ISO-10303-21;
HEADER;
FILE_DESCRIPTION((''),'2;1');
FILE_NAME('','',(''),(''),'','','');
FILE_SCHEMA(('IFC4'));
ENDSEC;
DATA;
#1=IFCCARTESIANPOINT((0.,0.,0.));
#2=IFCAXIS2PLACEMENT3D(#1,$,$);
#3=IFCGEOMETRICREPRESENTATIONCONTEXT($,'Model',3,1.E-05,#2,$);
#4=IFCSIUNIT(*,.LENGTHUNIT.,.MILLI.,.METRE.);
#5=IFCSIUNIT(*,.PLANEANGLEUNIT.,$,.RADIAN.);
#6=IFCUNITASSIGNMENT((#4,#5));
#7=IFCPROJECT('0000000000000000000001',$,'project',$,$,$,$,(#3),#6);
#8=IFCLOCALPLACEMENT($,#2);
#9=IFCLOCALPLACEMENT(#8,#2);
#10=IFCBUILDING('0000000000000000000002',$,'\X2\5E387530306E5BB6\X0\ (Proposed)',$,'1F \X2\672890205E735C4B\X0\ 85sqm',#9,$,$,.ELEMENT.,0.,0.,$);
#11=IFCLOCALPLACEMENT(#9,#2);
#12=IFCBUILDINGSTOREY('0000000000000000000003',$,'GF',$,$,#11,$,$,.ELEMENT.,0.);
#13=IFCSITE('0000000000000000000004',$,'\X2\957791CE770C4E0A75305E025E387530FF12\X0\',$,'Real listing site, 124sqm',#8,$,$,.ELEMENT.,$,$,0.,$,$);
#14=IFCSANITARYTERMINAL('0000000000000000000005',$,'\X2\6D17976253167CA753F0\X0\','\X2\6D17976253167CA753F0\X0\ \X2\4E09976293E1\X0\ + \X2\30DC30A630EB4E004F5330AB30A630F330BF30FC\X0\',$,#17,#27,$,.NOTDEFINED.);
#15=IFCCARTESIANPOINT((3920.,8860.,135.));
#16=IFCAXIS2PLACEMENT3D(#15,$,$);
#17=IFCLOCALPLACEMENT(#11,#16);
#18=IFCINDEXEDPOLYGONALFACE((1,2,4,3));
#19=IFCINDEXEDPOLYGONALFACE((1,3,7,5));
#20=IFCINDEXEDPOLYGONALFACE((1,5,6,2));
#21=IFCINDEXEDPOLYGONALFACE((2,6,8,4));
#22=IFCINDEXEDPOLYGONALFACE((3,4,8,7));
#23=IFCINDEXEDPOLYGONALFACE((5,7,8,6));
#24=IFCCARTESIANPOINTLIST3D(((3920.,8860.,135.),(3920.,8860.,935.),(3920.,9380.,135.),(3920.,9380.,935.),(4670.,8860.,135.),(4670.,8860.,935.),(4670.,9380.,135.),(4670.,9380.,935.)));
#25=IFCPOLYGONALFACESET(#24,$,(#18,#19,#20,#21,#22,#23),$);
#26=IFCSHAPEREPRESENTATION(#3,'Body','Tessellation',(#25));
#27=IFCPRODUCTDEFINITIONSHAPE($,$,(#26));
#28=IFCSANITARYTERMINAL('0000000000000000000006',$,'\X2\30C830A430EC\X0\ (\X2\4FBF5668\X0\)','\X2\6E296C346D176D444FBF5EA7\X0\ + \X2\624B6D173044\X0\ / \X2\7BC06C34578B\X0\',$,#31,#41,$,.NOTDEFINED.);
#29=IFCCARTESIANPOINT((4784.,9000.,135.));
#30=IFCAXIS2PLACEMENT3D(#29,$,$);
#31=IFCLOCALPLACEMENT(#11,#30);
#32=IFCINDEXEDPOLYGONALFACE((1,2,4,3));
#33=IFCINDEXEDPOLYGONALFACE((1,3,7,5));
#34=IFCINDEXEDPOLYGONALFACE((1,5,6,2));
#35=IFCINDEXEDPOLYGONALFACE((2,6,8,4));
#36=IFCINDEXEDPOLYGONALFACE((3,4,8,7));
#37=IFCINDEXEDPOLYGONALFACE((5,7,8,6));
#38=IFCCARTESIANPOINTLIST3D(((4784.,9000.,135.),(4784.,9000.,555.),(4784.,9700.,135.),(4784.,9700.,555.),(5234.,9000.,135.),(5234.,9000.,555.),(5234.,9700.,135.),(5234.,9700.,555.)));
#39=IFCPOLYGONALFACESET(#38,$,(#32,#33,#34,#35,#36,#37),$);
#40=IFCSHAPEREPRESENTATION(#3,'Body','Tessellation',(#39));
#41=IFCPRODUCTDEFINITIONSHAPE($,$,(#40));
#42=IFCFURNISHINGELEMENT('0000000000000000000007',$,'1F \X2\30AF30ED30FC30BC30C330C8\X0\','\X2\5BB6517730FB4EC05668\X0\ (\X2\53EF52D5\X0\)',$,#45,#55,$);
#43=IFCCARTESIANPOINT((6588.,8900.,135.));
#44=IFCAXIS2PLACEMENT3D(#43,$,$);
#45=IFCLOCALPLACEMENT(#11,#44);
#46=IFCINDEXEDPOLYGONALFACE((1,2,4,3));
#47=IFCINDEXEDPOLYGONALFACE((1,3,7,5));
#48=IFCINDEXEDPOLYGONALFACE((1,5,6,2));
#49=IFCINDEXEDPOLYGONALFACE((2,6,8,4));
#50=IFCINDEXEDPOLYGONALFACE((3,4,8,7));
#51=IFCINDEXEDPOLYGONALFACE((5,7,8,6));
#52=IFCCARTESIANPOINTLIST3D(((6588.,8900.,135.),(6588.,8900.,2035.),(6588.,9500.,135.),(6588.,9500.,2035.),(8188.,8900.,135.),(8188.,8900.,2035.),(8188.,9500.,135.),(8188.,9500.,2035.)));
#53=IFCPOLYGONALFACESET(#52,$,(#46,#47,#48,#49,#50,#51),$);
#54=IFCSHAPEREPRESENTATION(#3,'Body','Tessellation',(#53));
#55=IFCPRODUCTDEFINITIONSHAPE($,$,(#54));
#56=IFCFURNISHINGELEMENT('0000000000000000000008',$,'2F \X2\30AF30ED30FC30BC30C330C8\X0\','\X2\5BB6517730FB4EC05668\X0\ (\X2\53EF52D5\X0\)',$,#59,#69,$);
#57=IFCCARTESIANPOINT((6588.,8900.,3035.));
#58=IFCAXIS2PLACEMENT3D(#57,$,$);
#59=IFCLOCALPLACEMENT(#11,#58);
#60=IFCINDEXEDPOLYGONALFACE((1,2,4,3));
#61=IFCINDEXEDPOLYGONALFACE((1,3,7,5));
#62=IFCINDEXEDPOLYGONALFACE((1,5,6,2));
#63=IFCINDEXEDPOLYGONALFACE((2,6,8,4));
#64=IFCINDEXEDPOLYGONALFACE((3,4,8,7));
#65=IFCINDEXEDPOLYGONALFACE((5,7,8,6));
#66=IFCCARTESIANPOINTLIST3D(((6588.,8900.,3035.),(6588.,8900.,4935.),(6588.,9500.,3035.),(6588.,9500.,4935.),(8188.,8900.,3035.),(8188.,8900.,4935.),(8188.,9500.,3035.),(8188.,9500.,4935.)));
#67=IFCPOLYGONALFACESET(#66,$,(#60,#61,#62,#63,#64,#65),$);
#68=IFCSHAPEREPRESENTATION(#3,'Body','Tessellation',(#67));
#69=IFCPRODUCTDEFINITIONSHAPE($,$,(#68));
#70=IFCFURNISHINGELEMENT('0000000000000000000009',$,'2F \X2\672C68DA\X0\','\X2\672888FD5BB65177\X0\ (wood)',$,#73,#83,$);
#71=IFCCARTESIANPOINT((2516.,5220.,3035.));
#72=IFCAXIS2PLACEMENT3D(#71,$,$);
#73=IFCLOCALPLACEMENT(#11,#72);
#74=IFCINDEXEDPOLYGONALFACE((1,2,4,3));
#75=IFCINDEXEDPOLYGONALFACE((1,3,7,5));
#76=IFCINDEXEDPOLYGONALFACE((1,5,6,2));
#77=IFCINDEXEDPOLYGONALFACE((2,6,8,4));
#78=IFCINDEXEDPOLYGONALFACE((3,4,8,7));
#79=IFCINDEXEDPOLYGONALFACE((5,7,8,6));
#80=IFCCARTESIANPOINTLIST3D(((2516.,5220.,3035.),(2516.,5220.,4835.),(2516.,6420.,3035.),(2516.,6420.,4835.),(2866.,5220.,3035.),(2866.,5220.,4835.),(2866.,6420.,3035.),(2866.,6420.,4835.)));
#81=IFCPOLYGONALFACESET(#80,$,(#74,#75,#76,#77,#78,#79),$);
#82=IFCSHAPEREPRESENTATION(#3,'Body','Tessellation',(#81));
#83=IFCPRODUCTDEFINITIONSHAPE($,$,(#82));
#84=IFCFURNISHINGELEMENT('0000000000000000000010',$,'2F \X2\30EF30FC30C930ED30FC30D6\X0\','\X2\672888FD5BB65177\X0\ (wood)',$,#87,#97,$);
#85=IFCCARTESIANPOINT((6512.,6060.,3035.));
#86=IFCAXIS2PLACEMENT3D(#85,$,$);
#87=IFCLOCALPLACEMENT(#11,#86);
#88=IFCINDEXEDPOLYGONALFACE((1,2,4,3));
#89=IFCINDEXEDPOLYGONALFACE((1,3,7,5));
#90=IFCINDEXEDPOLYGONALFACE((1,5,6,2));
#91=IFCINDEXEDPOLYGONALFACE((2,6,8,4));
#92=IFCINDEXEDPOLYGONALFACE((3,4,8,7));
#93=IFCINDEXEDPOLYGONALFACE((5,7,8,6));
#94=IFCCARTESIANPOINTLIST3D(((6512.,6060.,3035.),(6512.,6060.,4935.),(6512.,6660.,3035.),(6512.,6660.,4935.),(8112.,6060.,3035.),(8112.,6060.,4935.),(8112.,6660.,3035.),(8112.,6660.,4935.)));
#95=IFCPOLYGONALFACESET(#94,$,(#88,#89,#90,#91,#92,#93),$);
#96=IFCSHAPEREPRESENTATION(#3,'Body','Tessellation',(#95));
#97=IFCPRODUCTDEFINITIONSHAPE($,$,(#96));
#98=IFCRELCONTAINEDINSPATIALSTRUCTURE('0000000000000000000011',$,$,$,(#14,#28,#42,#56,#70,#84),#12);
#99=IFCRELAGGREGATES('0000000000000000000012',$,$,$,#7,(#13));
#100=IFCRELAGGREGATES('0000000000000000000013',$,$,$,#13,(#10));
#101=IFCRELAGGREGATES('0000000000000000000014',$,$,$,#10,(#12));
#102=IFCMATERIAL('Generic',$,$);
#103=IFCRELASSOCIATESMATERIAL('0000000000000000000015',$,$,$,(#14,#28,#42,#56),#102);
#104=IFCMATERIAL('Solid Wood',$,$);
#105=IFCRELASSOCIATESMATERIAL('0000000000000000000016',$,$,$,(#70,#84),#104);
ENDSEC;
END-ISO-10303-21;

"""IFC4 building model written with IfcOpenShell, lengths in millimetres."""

from ifc_helpers import new_model, si_unit, frame, frame_2d, origin, place, context, project, spatial, rectangle, extrude, material, element, save


model = new_model("IFC4")

# Units and contexts
model_context = context("Model", 3, precision=1e-05, world=origin())
ifc_project = project(units=[si_unit("LENGTHUNIT", "METRE", prefix="MILLI"), si_unit("PLANEANGLEUNIT", "RADIAN")], contexts=[model_context])

# Site, building, storey
site_placement = place(None, origin())
site = spatial("IfcSite", under=ifc_project, at=site_placement, Name="長野県上田市常田２", ObjectType="Real listing site, 124sqm", CompositionType="ELEMENT", RefElevation=0.0)
building_placement = place(site_placement, origin())
building = spatial("IfcBuilding", under=site, at=building_placement, Name="常田の家 (Proposed)", ObjectType="1F 木造平屋 85sqm", CompositionType="ELEMENT", ElevationOfRefHeight=0.0, ElevationOfTerrain=0.0)
storey_placement = place(building_placement, origin())
storey = spatial("IfcBuildingStorey", under=building, at=storey_placement, Name="GF", CompositionType="ELEMENT", Elevation=0.0)

# Shared definitions
ifc_material_1 = material(Name="Solid Wood")

# Shared definitions
ifc_material_2 = material(Name="Generic")

# Sanitary terminals
sanitary_terminal_1_placement = place(storey_placement, frame((3920.0, 8860.0, 135.0)))
element("IfcSanitaryTerminal", 1, at=sanitary_terminal_1_placement, inside=storey, material=ifc_material_2, Name="洗面化粧台", Description="洗面化粧台 三面鏡 + ボウル一体カウンター", PredefinedType="NOTDEFINED", context=model_context, shape_type="SweptSolid", body=[
    extrude(rectangle(XDim=750.0, YDim=520.0, at=frame_2d((375.0, 260.0))), frame((3920.0, 8860.0, 135.0)), (0.0, 0.0, 1.0), 800.0),
])
sanitary_terminal_2_placement = place(storey_placement, frame((4784.0, 9000.0, 135.0)))
element("IfcSanitaryTerminal", 2, at=sanitary_terminal_2_placement, inside=storey, material=ifc_material_2, Name="トイレ (便器)", Description="温水洗浄便座 + 手洗い / 節水型", PredefinedType="NOTDEFINED", context=model_context, shape_type="SweptSolid", body=[
    extrude(rectangle(XDim=450.0, YDim=700.0, at=frame_2d((225.0, 350.0))), frame((4784.0, 9000.0, 135.0)), (0.0, 0.0, 1.0), 420.0),
])

# Furnishing elements
furnishing_1_placement = place(storey_placement, frame((6588.0, 8900.0, 135.0)))
element("IfcFurnishingElement", 3, at=furnishing_1_placement, inside=storey, material=ifc_material_2, Name="1F クローゼット", Description="家具・什器 (可動)", context=model_context, shape_type="SweptSolid", body=[
    extrude(rectangle(XDim=1600.0, YDim=600.0, at=frame_2d((800.0, 300.0))), frame((6588.0, 8900.0, 135.0)), (0.0, 0.0, 1.0), 1900.0),
])
furnishing_2_placement = place(storey_placement, frame((6588.0, 8900.0, 3035.0)))
element("IfcFurnishingElement", 4, at=furnishing_2_placement, inside=storey, material=ifc_material_2, Name="2F クローゼット", Description="家具・什器 (可動)", context=model_context, shape_type="SweptSolid", body=[
    extrude(rectangle(XDim=1600.0, YDim=600.0, at=frame_2d((800.0, 300.0))), frame((6588.0, 8900.0, 3035.0)), (0.0, 0.0, 1.0), 1900.0),
])
furnishing_3_placement = place(storey_placement, frame((2516.0, 5220.0, 3035.0)))
element("IfcFurnishingElement", 5, at=furnishing_3_placement, inside=storey, material=ifc_material_1, Name="2F 本棚", Description="木製家具 (wood)", context=model_context, shape_type="SweptSolid", body=[
    extrude(rectangle(XDim=350.0, YDim=1200.0, at=frame_2d((175.0, 600.0))), frame((2516.0, 5220.0, 3035.0)), (0.0, 0.0, 1.0), 1800.0),
])
furnishing_4_placement = place(storey_placement, frame((6512.0, 6060.0, 3035.0)))
element("IfcFurnishingElement", 6, at=furnishing_4_placement, inside=storey, material=ifc_material_1, Name="2F ワードローブ", Description="木製家具 (wood)", context=model_context, shape_type="SweptSolid", body=[
    extrude(rectangle(XDim=1600.0, YDim=600.0, at=frame_2d((800.0, 300.0))), frame((6512.0, 6060.0, 3035.0)), (0.0, 0.0, 1.0), 1900.0),
])

save(model, "model.ifc")
